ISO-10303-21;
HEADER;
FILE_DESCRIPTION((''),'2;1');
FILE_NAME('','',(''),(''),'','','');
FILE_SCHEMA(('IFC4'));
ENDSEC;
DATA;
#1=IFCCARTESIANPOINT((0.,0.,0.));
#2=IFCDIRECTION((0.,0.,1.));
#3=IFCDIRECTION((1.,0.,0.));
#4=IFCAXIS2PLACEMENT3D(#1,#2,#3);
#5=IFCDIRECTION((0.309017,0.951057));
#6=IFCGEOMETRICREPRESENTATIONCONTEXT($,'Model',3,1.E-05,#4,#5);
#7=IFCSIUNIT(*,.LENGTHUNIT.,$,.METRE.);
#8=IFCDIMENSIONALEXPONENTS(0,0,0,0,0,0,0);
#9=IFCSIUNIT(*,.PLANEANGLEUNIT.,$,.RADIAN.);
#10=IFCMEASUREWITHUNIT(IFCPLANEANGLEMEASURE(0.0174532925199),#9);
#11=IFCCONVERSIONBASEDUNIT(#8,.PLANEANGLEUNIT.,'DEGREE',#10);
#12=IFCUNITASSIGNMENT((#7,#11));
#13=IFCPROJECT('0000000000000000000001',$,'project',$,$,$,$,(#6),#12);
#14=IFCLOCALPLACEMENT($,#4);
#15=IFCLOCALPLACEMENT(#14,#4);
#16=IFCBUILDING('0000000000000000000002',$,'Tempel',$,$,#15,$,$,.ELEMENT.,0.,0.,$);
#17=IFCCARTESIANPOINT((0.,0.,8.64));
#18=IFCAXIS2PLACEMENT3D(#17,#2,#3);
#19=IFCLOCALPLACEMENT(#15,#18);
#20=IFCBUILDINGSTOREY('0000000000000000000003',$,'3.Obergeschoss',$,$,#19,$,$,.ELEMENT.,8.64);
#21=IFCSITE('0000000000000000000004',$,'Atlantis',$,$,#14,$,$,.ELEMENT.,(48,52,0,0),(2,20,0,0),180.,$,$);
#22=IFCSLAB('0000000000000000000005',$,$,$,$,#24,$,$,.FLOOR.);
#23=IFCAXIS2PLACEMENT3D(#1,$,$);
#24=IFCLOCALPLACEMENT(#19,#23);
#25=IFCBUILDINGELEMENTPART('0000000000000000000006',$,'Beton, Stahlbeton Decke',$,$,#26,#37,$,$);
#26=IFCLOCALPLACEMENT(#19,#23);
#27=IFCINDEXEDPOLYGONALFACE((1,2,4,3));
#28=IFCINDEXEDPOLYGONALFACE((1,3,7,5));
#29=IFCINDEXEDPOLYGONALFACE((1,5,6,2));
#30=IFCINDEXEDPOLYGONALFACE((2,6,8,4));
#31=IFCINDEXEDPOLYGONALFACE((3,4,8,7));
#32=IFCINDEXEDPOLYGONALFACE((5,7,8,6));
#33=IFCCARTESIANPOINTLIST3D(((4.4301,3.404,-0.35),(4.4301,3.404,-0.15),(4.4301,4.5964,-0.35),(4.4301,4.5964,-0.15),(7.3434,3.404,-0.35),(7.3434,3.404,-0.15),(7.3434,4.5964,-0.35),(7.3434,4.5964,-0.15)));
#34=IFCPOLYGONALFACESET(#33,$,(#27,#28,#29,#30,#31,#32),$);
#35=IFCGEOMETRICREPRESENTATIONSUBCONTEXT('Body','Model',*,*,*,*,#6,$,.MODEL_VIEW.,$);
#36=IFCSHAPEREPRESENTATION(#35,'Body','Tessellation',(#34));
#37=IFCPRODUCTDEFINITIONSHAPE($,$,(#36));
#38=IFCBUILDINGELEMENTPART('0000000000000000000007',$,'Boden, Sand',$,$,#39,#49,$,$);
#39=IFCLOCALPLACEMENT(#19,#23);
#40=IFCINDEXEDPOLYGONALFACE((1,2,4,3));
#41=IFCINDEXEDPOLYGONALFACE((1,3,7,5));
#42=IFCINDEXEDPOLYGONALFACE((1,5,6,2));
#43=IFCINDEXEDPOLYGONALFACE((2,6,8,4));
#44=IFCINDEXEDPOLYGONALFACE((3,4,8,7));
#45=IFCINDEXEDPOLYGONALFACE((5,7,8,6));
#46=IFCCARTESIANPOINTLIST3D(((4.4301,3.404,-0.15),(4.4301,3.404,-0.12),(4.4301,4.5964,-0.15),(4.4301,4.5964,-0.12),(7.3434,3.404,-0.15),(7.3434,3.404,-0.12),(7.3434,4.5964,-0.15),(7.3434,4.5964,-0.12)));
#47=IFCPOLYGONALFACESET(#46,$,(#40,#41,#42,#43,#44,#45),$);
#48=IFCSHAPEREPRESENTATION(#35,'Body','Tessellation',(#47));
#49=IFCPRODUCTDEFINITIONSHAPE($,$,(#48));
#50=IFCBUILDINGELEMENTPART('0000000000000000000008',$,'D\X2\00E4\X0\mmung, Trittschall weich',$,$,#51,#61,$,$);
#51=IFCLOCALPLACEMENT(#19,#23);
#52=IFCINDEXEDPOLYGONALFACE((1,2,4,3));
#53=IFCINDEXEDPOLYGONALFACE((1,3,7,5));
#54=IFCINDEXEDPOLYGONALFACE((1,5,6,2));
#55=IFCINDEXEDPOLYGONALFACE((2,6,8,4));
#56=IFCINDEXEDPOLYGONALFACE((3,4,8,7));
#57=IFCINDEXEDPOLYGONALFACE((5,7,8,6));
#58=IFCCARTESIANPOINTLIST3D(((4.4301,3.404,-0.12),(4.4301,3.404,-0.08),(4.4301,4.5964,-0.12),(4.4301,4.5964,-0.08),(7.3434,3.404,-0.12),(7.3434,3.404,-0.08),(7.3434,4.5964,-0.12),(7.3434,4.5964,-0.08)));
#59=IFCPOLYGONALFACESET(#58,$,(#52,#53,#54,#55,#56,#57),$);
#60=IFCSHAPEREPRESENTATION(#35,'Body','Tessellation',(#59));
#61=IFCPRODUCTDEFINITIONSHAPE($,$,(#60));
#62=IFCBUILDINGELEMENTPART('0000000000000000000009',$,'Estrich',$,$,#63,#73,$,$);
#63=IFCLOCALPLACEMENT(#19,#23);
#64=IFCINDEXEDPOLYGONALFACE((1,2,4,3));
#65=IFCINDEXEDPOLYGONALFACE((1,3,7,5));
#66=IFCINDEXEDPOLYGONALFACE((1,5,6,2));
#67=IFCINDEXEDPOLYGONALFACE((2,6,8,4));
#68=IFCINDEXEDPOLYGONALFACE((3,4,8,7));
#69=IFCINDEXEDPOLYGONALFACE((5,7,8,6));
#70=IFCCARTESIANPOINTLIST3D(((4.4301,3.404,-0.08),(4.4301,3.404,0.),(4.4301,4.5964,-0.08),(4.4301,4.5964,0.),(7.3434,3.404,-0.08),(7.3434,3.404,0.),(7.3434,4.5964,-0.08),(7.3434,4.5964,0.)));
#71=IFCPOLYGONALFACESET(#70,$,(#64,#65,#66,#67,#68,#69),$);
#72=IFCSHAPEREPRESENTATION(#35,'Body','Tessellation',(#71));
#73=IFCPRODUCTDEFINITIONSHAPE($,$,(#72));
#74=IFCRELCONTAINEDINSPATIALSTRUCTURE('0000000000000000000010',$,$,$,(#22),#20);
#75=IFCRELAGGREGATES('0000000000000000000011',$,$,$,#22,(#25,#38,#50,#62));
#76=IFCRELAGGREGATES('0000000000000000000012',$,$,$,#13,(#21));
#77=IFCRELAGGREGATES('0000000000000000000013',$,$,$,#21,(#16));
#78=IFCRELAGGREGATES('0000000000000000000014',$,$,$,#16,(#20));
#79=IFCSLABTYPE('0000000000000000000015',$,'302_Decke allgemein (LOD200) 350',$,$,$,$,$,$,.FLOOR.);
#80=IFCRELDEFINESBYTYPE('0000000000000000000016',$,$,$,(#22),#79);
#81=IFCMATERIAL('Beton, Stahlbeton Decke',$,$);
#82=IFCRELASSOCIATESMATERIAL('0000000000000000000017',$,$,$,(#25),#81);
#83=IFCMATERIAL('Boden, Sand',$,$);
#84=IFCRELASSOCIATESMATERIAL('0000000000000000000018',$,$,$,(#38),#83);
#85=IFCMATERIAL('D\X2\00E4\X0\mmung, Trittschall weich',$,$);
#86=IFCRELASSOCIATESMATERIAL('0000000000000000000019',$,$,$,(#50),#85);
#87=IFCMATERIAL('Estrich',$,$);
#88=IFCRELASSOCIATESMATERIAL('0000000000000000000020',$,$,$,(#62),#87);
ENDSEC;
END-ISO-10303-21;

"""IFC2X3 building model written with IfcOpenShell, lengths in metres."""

from ifc_helpers import new_model, entity, si_unit, converted_unit, direction, frame, origin_with_axes, place, context, subcontext, project, spatial, polyline, outline, extrude, material, type_object, element, aggregate, save


model = new_model("IFC2X3")

# Units and contexts
model_context = context("Model", 3, precision=1e-05, world=origin_with_axes(), true_north=direction((0.309017, 0.951057)))
body_context = subcontext(model_context, "Body", "Model", "MODEL_VIEW")
ifc_project = project(units=[si_unit("LENGTHUNIT", "METRE"), converted_unit("PLANEANGLEUNIT", "DEGREE", entity("IfcPlaneAngleMeasure", 0.0174532925199), si_unit("PLANEANGLEUNIT", "RADIAN"), dimensions=[0, 0, 0, 0, 0, 0, 0])], contexts=[model_context])

# Site, building, storey
site_placement = place(None, origin_with_axes())
site = spatial("IfcSite", under=ifc_project, at=site_placement, Name="Atlantis", CompositionType="ELEMENT", RefLatitude=(48, 52, 0, 0), RefLongitude=(2, 20, 0, 0), RefElevation=180.0)
building_placement = place(site_placement, origin_with_axes())
building = spatial("IfcBuilding", under=site, at=building_placement, Name="Tempel", CompositionType="ELEMENT", ElevationOfRefHeight=0.0, ElevationOfTerrain=0.0)
storey_placement = place(building_placement, frame((0.0, 0.0, 8.64), z_axis=(0.0, 0.0, 1.0), x_axis=(1.0, 0.0, 0.0)))
storey = spatial("IfcBuildingStorey", under=building, at=storey_placement, Name="3.Obergeschoss", CompositionType="ELEMENT", Elevation=8.64)

# Slab, building element parts
slab_type = type_object("IfcSlabType", Name="302_Decke allgemein (LOD200) 350", PredefinedType="FLOOR")
slab_placement = place(storey_placement, frame((4.4301, 3.404, -0.15), z_axis=(0.0, 0.0, 1.0), x_axis=(1.0, 0.0, 0.0)))
slab = element("IfcSlab", 1, at=slab_placement, inside=storey, type_object=slab_type, PredefinedType="FLOOR")
ifc_material_1 = material(Name="Beton, Stahlbeton Decke")
building_element_part_1_placement = place(slab_placement, origin_with_axes())
building_element_part_1 = element("IfcBuildingElementPart", 2, at=building_element_part_1_placement, material=ifc_material_1, Name="Beton, Stahlbeton Decke", context=body_context, shape_type="SweptSolid", body=[
    extrude(outline(polyline([(0.0, 0.0), (2.9133, 0.0), (2.9133, 1.1924), (0.0, 1.1924), (0.0, 0.0)])), frame((0.0, 0.0, -0.2), z_axis=(0.0, 0.0, 1.0), x_axis=(1.0, 0.0, 0.0)), (0.0, 0.0, 1.0), 0.2),
])
ifc_material_2 = material(Name="Boden, Sand")
building_element_part_2_placement = place(slab_placement, origin_with_axes())
building_element_part_2 = element("IfcBuildingElementPart", 3, at=building_element_part_2_placement, material=ifc_material_2, Name="Boden, Sand", context=body_context, shape_type="SweptSolid", body=[
    extrude(outline(polyline([(0.0, 0.0), (2.9133, 0.0), (2.9133, 1.1924), (0.0, 1.1924), (0.0, 0.0)])), origin_with_axes(), (0.0, 0.0, 1.0), 0.03),
])
ifc_material_3 = material(Name="Dämmung, Trittschall weich")
building_element_part_3_placement = place(slab_placement, origin_with_axes())
building_element_part_3 = element("IfcBuildingElementPart", 4, at=building_element_part_3_placement, material=ifc_material_3, Name="Dämmung, Trittschall weich", context=body_context, shape_type="SweptSolid", body=[
    extrude(outline(polyline([(0.0, 0.0), (2.9133, 0.0), (2.9133, 1.1924), (0.0, 1.1924), (0.0, 0.0)])), frame((0.0, 0.0, 0.03), z_axis=(0.0, 0.0, 1.0), x_axis=(1.0, 0.0, 0.0)), (0.0, 0.0, 1.0), 0.04),
])
ifc_material_4 = material(Name="Estrich")
building_element_part_4_placement = place(slab_placement, origin_with_axes())
building_element_part_4 = element("IfcBuildingElementPart", 5, at=building_element_part_4_placement, material=ifc_material_4, Name="Estrich", context=body_context, shape_type="SweptSolid", body=[
    extrude(outline(polyline([(0.0, 0.0), (2.9133, 0.0), (2.9133, 1.1924), (0.0, 1.1924), (0.0, 0.0)])), frame((0.0, 0.0, 0.07), z_axis=(0.0, 0.0, 1.0), x_axis=(1.0, 0.0, 0.0)), (0.0, 0.0, 1.0), 0.08),
])
aggregate(slab, [building_element_part_1, building_element_part_2, building_element_part_3, building_element_part_4])

save(model, "model.ifc")
